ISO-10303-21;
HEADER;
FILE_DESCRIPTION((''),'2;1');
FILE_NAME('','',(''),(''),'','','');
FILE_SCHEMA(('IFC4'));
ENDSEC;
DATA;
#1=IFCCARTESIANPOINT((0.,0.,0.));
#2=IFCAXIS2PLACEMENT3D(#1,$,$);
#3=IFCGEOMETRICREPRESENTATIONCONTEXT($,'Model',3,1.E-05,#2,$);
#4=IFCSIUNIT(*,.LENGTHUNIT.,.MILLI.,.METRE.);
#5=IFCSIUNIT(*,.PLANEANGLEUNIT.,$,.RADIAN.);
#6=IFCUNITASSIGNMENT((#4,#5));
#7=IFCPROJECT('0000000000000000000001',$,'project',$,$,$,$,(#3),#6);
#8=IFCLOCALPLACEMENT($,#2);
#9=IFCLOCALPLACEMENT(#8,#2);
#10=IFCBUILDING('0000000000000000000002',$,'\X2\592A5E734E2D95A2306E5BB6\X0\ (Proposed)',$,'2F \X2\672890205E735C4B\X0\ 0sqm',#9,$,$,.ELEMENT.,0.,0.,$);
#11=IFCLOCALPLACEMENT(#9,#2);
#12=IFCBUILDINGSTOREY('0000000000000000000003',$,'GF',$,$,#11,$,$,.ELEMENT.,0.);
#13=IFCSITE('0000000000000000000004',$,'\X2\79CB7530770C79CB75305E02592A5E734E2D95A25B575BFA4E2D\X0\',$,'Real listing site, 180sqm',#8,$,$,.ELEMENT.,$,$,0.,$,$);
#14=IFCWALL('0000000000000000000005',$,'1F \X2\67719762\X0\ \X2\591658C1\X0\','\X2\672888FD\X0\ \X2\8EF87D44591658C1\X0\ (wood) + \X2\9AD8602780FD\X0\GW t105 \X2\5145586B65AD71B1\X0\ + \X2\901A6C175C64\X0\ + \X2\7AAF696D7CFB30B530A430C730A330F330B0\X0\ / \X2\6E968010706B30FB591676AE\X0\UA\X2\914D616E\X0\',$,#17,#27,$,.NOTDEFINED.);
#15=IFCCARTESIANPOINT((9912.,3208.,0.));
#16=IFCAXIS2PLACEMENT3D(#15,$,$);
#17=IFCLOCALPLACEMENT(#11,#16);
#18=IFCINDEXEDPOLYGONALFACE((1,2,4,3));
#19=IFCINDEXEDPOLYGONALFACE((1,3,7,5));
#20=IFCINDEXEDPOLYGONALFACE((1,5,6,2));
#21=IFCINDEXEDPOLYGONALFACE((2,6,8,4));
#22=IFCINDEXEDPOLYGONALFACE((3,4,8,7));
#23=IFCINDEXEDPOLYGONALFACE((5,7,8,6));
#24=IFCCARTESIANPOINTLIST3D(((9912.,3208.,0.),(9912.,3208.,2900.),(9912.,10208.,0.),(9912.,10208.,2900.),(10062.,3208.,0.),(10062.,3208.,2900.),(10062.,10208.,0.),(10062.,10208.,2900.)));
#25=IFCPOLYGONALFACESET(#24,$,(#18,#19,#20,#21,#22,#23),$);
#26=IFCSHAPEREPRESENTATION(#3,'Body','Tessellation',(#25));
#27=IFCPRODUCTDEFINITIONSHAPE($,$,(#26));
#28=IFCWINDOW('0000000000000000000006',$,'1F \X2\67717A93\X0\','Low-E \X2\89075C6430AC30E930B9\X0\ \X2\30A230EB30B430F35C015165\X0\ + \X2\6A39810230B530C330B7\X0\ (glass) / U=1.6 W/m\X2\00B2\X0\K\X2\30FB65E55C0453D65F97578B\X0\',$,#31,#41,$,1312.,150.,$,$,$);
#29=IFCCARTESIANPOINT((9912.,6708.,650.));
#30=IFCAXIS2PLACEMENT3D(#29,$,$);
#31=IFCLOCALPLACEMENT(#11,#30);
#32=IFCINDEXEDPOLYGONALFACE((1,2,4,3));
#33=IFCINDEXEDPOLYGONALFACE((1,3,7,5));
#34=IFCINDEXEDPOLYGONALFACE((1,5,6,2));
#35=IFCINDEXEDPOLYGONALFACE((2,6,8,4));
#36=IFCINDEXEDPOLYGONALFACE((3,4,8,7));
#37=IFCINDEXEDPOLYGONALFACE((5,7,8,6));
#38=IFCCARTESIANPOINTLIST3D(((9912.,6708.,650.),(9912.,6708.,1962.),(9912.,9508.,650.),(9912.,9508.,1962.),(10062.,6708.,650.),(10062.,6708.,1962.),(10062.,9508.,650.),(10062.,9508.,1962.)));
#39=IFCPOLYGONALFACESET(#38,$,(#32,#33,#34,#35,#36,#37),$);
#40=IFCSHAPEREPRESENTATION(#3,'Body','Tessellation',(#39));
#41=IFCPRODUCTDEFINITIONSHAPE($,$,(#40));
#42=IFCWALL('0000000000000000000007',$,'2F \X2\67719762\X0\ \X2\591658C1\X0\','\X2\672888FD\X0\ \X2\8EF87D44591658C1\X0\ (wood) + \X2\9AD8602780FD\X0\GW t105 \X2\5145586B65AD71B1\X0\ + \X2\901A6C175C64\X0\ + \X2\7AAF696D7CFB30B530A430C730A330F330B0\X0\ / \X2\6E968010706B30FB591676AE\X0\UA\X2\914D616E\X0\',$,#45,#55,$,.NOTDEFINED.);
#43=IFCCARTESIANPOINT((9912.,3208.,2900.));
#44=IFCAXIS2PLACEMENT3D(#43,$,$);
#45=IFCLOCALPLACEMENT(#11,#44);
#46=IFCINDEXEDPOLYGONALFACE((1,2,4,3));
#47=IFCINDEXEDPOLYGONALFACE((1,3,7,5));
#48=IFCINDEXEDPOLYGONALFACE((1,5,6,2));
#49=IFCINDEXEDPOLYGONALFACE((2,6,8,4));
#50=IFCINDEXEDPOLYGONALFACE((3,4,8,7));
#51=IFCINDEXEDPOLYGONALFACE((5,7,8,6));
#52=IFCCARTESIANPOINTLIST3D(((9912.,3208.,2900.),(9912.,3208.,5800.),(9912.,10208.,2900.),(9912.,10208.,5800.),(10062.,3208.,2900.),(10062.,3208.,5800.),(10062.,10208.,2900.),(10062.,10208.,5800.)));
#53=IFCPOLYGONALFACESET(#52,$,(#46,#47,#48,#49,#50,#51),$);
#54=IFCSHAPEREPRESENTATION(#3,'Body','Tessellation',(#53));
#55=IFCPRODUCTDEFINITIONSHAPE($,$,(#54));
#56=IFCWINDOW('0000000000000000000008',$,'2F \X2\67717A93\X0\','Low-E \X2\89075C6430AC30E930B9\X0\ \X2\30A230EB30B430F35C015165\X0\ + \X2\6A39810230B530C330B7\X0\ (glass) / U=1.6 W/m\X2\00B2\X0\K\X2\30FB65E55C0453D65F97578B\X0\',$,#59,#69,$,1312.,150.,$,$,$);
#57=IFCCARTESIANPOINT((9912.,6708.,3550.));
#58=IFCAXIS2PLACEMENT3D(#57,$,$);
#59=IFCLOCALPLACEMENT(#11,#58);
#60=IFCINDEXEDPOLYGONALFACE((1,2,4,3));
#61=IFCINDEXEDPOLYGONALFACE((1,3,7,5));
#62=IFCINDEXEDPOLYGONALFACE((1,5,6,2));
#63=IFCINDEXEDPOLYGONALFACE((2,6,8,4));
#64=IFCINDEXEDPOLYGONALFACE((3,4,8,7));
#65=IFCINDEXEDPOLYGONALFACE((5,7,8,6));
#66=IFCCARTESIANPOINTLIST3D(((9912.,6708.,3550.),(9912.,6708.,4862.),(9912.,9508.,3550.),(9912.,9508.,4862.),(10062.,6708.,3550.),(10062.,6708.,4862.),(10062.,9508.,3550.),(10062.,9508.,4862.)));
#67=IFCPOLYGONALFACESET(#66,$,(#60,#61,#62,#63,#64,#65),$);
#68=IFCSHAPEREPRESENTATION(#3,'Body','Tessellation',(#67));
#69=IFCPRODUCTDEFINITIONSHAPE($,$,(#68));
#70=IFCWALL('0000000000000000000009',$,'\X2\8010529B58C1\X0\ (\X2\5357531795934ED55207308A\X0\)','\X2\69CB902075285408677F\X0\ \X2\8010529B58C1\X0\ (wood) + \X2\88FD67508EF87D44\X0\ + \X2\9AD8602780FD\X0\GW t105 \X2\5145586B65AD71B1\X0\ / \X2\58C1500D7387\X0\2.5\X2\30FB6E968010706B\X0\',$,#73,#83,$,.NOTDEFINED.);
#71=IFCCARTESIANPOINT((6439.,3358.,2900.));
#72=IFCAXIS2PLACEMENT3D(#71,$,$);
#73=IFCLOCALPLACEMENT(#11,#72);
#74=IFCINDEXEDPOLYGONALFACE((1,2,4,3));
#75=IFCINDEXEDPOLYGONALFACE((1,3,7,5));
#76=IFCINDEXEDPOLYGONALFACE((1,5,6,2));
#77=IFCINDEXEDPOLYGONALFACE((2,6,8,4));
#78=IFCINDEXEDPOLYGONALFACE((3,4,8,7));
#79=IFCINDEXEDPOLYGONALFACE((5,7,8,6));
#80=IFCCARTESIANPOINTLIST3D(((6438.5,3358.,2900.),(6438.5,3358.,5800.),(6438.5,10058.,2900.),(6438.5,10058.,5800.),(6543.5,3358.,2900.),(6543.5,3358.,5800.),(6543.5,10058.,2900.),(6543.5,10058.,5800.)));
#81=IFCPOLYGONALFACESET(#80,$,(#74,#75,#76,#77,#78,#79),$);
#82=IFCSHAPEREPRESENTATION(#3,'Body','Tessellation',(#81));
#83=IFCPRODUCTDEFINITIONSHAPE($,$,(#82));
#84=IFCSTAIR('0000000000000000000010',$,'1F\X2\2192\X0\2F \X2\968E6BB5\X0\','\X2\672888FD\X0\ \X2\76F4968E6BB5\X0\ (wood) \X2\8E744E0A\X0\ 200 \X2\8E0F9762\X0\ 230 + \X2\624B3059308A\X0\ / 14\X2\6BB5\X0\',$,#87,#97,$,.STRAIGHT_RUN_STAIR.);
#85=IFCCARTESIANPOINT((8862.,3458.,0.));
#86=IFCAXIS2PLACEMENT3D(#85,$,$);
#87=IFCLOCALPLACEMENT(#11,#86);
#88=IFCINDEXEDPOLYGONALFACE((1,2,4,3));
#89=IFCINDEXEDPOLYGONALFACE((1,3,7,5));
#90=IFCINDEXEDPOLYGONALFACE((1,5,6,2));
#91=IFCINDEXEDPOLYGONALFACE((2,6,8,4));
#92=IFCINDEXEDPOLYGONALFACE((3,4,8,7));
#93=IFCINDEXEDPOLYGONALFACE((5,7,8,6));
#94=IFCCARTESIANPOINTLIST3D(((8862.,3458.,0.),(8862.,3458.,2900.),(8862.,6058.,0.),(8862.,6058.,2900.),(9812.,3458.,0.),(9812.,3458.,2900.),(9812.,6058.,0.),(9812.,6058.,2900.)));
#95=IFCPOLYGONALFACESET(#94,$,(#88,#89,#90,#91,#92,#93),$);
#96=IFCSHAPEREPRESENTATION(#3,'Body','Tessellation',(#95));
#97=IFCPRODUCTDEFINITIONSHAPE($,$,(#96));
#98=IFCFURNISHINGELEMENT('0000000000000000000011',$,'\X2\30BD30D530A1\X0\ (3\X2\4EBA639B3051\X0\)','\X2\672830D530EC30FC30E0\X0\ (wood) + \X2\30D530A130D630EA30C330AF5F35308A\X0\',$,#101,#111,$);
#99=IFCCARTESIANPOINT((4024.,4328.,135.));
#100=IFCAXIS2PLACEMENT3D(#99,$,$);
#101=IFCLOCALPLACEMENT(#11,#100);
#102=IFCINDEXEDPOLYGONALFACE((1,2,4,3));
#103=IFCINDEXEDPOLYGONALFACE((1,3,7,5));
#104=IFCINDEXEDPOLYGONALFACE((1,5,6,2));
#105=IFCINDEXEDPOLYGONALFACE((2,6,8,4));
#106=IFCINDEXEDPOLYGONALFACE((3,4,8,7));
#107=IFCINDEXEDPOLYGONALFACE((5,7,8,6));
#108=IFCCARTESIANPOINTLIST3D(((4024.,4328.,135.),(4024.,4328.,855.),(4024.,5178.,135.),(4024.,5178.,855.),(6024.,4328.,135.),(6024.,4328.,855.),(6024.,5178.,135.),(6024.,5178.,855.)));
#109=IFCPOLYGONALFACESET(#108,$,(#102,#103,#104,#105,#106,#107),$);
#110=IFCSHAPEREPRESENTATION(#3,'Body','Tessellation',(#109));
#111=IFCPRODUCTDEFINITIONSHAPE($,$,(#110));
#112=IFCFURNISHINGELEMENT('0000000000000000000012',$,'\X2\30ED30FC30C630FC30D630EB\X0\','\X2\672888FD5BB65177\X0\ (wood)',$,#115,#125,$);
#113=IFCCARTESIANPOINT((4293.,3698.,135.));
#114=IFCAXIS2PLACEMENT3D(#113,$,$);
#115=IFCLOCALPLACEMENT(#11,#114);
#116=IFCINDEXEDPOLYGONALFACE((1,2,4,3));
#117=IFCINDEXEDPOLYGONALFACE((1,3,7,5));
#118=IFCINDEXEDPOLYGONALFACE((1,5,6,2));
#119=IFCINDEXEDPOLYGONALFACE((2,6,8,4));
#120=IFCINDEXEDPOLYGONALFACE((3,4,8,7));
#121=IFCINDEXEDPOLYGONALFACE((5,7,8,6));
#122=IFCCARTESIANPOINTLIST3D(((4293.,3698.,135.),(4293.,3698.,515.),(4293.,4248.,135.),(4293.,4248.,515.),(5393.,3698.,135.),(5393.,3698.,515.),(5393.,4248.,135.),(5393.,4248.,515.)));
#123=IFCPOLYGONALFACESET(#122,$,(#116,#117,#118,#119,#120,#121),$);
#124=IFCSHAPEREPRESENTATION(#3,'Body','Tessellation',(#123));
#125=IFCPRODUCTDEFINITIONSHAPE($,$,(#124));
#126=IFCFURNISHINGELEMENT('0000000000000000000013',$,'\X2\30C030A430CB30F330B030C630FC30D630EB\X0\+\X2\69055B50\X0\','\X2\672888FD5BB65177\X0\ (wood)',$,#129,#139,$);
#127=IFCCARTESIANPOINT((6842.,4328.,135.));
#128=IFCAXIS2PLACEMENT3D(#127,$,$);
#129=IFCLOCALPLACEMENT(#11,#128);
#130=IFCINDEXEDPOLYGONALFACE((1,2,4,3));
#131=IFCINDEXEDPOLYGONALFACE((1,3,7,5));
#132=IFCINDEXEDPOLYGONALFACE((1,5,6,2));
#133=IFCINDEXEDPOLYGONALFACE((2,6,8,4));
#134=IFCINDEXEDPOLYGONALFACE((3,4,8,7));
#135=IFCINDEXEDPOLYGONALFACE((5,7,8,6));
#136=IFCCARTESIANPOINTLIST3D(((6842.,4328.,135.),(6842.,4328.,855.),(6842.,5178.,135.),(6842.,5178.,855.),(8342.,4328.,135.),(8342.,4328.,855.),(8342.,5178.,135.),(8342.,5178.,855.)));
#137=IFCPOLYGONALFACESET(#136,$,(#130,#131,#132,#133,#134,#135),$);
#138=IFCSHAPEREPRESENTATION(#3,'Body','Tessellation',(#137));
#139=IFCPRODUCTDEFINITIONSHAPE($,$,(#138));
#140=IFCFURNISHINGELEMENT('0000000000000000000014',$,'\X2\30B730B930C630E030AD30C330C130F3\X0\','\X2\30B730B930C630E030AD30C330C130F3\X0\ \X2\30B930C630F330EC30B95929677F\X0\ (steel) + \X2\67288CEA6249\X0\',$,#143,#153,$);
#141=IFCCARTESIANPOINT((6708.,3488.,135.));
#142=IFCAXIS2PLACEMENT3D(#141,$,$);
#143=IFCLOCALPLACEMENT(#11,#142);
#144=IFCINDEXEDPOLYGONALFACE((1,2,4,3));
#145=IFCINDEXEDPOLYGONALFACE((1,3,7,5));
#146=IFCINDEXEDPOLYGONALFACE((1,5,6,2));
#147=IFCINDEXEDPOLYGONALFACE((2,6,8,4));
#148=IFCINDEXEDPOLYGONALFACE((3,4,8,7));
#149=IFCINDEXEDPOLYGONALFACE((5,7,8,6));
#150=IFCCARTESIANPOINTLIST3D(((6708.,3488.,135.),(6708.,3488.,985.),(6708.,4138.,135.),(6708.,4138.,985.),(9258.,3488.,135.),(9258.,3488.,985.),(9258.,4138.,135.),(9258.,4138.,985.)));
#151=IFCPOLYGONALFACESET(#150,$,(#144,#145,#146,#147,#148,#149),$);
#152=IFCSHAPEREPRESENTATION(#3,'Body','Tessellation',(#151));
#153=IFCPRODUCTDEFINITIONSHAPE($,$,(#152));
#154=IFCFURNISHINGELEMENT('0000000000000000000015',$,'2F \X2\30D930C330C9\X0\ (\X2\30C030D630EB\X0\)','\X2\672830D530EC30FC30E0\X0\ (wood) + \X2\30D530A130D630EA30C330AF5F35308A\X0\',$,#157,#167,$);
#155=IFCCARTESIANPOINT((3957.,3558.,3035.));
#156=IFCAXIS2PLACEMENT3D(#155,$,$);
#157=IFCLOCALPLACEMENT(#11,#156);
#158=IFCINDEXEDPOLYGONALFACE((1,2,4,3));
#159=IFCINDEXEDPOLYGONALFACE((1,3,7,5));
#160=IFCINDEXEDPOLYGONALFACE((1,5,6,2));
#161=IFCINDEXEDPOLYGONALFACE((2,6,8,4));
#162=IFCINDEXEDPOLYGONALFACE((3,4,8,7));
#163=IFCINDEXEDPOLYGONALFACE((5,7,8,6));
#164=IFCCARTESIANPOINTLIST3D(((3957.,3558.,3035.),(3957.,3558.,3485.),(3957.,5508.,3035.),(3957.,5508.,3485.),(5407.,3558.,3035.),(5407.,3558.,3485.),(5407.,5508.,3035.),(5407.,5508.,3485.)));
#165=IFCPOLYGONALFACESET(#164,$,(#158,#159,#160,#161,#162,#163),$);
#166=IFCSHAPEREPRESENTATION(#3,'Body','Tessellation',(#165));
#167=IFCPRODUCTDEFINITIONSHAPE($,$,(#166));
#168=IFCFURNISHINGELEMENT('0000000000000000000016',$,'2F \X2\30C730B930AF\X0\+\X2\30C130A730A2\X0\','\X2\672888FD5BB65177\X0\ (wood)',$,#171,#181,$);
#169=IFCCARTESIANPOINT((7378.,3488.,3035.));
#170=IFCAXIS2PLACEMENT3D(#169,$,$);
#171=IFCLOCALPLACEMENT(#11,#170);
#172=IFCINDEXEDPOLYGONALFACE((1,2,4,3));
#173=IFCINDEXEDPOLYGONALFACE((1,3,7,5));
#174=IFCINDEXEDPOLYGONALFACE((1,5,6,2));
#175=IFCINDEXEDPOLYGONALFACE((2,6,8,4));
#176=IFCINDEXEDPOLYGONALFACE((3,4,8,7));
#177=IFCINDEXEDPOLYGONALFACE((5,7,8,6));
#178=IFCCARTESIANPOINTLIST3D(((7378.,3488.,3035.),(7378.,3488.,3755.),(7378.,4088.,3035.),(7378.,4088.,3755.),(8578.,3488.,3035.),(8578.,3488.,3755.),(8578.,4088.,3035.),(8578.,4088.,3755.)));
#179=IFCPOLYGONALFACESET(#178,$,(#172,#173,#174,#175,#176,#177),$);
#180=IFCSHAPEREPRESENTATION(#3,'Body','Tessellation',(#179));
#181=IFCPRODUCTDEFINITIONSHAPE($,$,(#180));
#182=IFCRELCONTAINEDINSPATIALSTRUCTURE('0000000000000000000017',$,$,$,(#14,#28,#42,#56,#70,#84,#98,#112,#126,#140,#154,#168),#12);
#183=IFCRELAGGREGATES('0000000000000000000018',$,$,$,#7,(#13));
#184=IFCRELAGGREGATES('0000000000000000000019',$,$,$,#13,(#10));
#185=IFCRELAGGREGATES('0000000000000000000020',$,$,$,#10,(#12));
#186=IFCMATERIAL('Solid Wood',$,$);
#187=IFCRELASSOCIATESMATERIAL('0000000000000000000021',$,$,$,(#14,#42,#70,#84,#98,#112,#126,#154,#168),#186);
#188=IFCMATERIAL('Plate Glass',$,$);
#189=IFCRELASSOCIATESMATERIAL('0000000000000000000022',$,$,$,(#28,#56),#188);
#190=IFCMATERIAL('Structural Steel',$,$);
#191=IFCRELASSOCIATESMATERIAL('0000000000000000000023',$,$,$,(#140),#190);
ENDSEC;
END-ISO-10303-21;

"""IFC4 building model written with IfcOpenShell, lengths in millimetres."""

from ifc_helpers import new_model, si_unit, frame, frame_2d, origin, place, context, project, spatial, rectangle, extrude, material, element, fill, save


model = new_model("IFC4")

# Units and contexts
model_context = context("Model", 3, precision=1e-05, world=origin())
ifc_project = project(units=[si_unit("LENGTHUNIT", "METRE", prefix="MILLI"), si_unit("PLANEANGLEUNIT", "RADIAN")], contexts=[model_context])

# Site, building, storey
site_placement = place(None, origin())
site = spatial("IfcSite", under=ifc_project, at=site_placement, Name="秋田県秋田市太平中関字寺中", ObjectType="Real listing site, 180sqm", CompositionType="ELEMENT", RefElevation=0.0)
building_placement = place(site_placement, origin())
building = spatial("IfcBuilding", under=site, at=building_placement, Name="太平中関の家 (Proposed)", ObjectType="2F 木造平屋 0sqm", CompositionType="ELEMENT", ElevationOfRefHeight=0.0, ElevationOfTerrain=0.0)
storey_placement = place(building_placement, origin())
storey = spatial("IfcBuildingStorey", under=building, at=storey_placement, Name="GF", CompositionType="ELEMENT", Elevation=0.0)

# Wall, opening, window
ifc_material_1 = material(Name="Solid Wood")
wall_1_placement = place(storey_placement, frame((9912.0, 3208.0, 0.0)))
wall_1 = element("IfcWall", 1, at=wall_1_placement, inside=storey, material=ifc_material_1, Name="1F 東面 外壁", Description="木製 軸組外壁 (wood) + 高性能GW t105 充填断熱 + 通気層 + 窯業系サイディング / 準耐火・外皮UA配慮", PredefinedType="NOTDEFINED", context=model_context, shape_type="SweptSolid", body=[
    extrude(rectangle(XDim=150.0, YDim=7000.0, at=frame_2d((75.0, 3500.0))), frame((9912.0, 3208.0, 0.0)), (0.0, 0.0, 1.0), 2900.0),
])
opening_1_placement = place(storey_placement, frame((9912.0, 6708.0, 650.0)))
opening_1 = element("IfcOpeningElement", 2, at=opening_1_placement, cuts=wall_1, PredefinedType="NOTDEFINED", context=model_context, shape_type="SweptSolid", body=[
    extrude(rectangle(XDim=150.0, YDim=2800.0, at=frame_2d((75.0, 1400.0))), frame((9912.0, 6708.0, 650.0)), (0.0, 0.0, 1.0), 1312.0),
])
ifc_material_2 = material(Name="Plate Glass")
window_1_placement = place(storey_placement, frame((9912.0, 6708.0, 650.0)))
window_1 = element("IfcWindow", 3, at=window_1_placement, inside=storey, material=ifc_material_2, Name="1F 東窓", Description="Low-E 複層ガラス アルゴン封入 + 樹脂サッシ (glass) / U=1.6 W/m²K・日射取得型", OverallHeight=1312.0, OverallWidth=150.0, context=model_context, shape_type="SweptSolid", body=[
    extrude(rectangle(XDim=150.0, YDim=2800.0, at=frame_2d((75.0, 1400.0))), frame((9912.0, 6708.0, 650.0)), (0.0, 0.0, 1.0), 1312.0),
])
fill(opening_1, window_1)

# Wall, opening, window
wall_2_placement = place(storey_placement, frame((9912.0, 3208.0, 2900.0)))
wall_2 = element("IfcWall", 4, at=wall_2_placement, inside=storey, material=ifc_material_1, Name="2F 東面 外壁", Description="木製 軸組外壁 (wood) + 高性能GW t105 充填断熱 + 通気層 + 窯業系サイディング / 準耐火・外皮UA配慮", PredefinedType="NOTDEFINED", context=model_context, shape_type="SweptSolid", body=[
    extrude(rectangle(XDim=150.0, YDim=7000.0, at=frame_2d((75.0, 3500.0))), frame((9912.0, 3208.0, 2900.0)), (0.0, 0.0, 1.0), 2900.0),
])
opening_2_placement = place(storey_placement, frame((9912.0, 6708.0, 3550.0)))
opening_2 = element("IfcOpeningElement", 5, at=opening_2_placement, cuts=wall_2, PredefinedType="NOTDEFINED", context=model_context, shape_type="SweptSolid", body=[
    extrude(rectangle(XDim=150.0, YDim=2800.0, at=frame_2d((75.0, 1400.0))), frame((9912.0, 6708.0, 3550.0)), (0.0, 0.0, 1.0), 1312.0),
])
window_2_placement = place(storey_placement, frame((9912.0, 6708.0, 3550.0)))
window_2 = element("IfcWindow", 6, at=window_2_placement, inside=storey, material=ifc_material_2, Name="2F 東窓", Description="Low-E 複層ガラス アルゴン封入 + 樹脂サッシ (glass) / U=1.6 W/m²K・日射取得型", OverallHeight=1312.0, OverallWidth=150.0, context=model_context, shape_type="SweptSolid", body=[
    extrude(rectangle(XDim=150.0, YDim=2800.0, at=frame_2d((75.0, 1400.0))), frame((9912.0, 6708.0, 3550.0)), (0.0, 0.0, 1.0), 1312.0),
])
fill(opening_2, window_2)

# Wall
wall_3_placement = place(storey_placement, frame((6439.0, 3358.0, 2900.0)))
element("IfcWall", 7, at=wall_3_placement, inside=storey, material=ifc_material_1, Name="耐力壁 (南北間仕切り)", Description="構造用合板 耐力壁 (wood) + 製材軸組 + 高性能GW t105 充填断熱 / 壁倍率2.5・準耐火", PredefinedType="NOTDEFINED", context=model_context, shape_type="SweptSolid", body=[
    extrude(rectangle(XDim=105.0, YDim=6700.0, at=frame_2d((52.0, 3350.0))), frame((6439.0, 3358.0, 2900.0)), (0.0, 0.0, 1.0), 2900.0),
])

# Stair
stair_placement = place(storey_placement, frame((8862.0, 3458.0, 0.0)))
element("IfcStair", 8, at=stair_placement, inside=storey, material=ifc_material_1, Name="1F→2F 階段", Description="木製 直階段 (wood) 蹴上 200 踏面 230 + 手すり / 14段", PredefinedType="STRAIGHT_RUN_STAIR", context=model_context, shape_type="SweptSolid", body=[
    extrude(rectangle(XDim=950.0, YDim=2600.0, at=frame_2d((475.0, 1300.0))), frame((8862.0, 3458.0, 0.0)), (0.0, 0.0, 1.0), 2900.0),
])

# Furnishing elements
furnishing_1_placement = place(storey_placement, frame((4024.0, 4328.0, 135.0)))
element("IfcFurnishingElement", 9, at=furnishing_1_placement, inside=storey, material=ifc_material_1, Name="ソファ (3人掛け)", Description="木フレーム (wood) + ファブリック張り", context=model_context, shape_type="SweptSolid", body=[
    extrude(rectangle(XDim=2000.0, YDim=850.0, at=frame_2d((1000.0, 425.0))), frame((4024.0, 4328.0, 135.0)), (0.0, 0.0, 1.0), 720.0),
])
furnishing_2_placement = place(storey_placement, frame((4293.0, 3698.0, 135.0)))
element("IfcFurnishingElement", 10, at=furnishing_2_placement, inside=storey, material=ifc_material_1, Name="ローテーブル", Description="木製家具 (wood)", context=model_context, shape_type="SweptSolid", body=[
    extrude(rectangle(XDim=1100.0, YDim=550.0, at=frame_2d((550.0, 275.0))), frame((4293.0, 3698.0, 135.0)), (0.0, 0.0, 1.0), 380.0),
])
furnishing_3_placement = place(storey_placement, frame((6842.0, 4328.0, 135.0)))
element("IfcFurnishingElement", 11, at=furnishing_3_placement, inside=storey, material=ifc_material_1, Name="ダイニングテーブル+椅子", Description="木製家具 (wood)", context=model_context, shape_type="SweptSolid", body=[
    extrude(rectangle(XDim=1500.0, YDim=850.0, at=frame_2d((750.0, 425.0))), frame((6842.0, 4328.0, 135.0)), (0.0, 0.0, 1.0), 720.0),
])
ifc_material_3 = material(Name="Structural Steel")
furnishing_4_placement = place(storey_placement, frame((6708.0, 3488.0, 135.0)))
element("IfcFurnishingElement", 12, at=furnishing_4_placement, inside=storey, material=ifc_material_3, Name="システムキッチン", Description="システムキッチン ステンレス天板 (steel) + 木質扉", context=model_context, shape_type="SweptSolid", body=[
    extrude(rectangle(XDim=2550.0, YDim=650.0, at=frame_2d((1275.0, 325.0))), frame((6708.0, 3488.0, 135.0)), (0.0, 0.0, 1.0), 850.0),
])
furnishing_5_placement = place(storey_placement, frame((3957.0, 3558.0, 3035.0)))
element("IfcFurnishingElement", 13, at=furnishing_5_placement, inside=storey, material=ifc_material_1, Name="2F ベッド (ダブル)", Description="木フレーム (wood) + ファブリック張り", context=model_context, shape_type="SweptSolid", body=[
    extrude(rectangle(XDim=1450.0, YDim=1950.0, at=frame_2d((725.0, 975.0))), frame((3957.0, 3558.0, 3035.0)), (0.0, 0.0, 1.0), 450.0),
])
furnishing_6_placement = place(storey_placement, frame((7378.0, 3488.0, 3035.0)))
element("IfcFurnishingElement", 14, at=furnishing_6_placement, inside=storey, material=ifc_material_1, Name="2F デスク+チェア", Description="木製家具 (wood)", context=model_context, shape_type="SweptSolid", body=[
    extrude(rectangle(XDim=1200.0, YDim=600.0, at=frame_2d((600.0, 300.0))), frame((7378.0, 3488.0, 3035.0)), (0.0, 0.0, 1.0), 720.0),
])

save(model, "model.ifc")
